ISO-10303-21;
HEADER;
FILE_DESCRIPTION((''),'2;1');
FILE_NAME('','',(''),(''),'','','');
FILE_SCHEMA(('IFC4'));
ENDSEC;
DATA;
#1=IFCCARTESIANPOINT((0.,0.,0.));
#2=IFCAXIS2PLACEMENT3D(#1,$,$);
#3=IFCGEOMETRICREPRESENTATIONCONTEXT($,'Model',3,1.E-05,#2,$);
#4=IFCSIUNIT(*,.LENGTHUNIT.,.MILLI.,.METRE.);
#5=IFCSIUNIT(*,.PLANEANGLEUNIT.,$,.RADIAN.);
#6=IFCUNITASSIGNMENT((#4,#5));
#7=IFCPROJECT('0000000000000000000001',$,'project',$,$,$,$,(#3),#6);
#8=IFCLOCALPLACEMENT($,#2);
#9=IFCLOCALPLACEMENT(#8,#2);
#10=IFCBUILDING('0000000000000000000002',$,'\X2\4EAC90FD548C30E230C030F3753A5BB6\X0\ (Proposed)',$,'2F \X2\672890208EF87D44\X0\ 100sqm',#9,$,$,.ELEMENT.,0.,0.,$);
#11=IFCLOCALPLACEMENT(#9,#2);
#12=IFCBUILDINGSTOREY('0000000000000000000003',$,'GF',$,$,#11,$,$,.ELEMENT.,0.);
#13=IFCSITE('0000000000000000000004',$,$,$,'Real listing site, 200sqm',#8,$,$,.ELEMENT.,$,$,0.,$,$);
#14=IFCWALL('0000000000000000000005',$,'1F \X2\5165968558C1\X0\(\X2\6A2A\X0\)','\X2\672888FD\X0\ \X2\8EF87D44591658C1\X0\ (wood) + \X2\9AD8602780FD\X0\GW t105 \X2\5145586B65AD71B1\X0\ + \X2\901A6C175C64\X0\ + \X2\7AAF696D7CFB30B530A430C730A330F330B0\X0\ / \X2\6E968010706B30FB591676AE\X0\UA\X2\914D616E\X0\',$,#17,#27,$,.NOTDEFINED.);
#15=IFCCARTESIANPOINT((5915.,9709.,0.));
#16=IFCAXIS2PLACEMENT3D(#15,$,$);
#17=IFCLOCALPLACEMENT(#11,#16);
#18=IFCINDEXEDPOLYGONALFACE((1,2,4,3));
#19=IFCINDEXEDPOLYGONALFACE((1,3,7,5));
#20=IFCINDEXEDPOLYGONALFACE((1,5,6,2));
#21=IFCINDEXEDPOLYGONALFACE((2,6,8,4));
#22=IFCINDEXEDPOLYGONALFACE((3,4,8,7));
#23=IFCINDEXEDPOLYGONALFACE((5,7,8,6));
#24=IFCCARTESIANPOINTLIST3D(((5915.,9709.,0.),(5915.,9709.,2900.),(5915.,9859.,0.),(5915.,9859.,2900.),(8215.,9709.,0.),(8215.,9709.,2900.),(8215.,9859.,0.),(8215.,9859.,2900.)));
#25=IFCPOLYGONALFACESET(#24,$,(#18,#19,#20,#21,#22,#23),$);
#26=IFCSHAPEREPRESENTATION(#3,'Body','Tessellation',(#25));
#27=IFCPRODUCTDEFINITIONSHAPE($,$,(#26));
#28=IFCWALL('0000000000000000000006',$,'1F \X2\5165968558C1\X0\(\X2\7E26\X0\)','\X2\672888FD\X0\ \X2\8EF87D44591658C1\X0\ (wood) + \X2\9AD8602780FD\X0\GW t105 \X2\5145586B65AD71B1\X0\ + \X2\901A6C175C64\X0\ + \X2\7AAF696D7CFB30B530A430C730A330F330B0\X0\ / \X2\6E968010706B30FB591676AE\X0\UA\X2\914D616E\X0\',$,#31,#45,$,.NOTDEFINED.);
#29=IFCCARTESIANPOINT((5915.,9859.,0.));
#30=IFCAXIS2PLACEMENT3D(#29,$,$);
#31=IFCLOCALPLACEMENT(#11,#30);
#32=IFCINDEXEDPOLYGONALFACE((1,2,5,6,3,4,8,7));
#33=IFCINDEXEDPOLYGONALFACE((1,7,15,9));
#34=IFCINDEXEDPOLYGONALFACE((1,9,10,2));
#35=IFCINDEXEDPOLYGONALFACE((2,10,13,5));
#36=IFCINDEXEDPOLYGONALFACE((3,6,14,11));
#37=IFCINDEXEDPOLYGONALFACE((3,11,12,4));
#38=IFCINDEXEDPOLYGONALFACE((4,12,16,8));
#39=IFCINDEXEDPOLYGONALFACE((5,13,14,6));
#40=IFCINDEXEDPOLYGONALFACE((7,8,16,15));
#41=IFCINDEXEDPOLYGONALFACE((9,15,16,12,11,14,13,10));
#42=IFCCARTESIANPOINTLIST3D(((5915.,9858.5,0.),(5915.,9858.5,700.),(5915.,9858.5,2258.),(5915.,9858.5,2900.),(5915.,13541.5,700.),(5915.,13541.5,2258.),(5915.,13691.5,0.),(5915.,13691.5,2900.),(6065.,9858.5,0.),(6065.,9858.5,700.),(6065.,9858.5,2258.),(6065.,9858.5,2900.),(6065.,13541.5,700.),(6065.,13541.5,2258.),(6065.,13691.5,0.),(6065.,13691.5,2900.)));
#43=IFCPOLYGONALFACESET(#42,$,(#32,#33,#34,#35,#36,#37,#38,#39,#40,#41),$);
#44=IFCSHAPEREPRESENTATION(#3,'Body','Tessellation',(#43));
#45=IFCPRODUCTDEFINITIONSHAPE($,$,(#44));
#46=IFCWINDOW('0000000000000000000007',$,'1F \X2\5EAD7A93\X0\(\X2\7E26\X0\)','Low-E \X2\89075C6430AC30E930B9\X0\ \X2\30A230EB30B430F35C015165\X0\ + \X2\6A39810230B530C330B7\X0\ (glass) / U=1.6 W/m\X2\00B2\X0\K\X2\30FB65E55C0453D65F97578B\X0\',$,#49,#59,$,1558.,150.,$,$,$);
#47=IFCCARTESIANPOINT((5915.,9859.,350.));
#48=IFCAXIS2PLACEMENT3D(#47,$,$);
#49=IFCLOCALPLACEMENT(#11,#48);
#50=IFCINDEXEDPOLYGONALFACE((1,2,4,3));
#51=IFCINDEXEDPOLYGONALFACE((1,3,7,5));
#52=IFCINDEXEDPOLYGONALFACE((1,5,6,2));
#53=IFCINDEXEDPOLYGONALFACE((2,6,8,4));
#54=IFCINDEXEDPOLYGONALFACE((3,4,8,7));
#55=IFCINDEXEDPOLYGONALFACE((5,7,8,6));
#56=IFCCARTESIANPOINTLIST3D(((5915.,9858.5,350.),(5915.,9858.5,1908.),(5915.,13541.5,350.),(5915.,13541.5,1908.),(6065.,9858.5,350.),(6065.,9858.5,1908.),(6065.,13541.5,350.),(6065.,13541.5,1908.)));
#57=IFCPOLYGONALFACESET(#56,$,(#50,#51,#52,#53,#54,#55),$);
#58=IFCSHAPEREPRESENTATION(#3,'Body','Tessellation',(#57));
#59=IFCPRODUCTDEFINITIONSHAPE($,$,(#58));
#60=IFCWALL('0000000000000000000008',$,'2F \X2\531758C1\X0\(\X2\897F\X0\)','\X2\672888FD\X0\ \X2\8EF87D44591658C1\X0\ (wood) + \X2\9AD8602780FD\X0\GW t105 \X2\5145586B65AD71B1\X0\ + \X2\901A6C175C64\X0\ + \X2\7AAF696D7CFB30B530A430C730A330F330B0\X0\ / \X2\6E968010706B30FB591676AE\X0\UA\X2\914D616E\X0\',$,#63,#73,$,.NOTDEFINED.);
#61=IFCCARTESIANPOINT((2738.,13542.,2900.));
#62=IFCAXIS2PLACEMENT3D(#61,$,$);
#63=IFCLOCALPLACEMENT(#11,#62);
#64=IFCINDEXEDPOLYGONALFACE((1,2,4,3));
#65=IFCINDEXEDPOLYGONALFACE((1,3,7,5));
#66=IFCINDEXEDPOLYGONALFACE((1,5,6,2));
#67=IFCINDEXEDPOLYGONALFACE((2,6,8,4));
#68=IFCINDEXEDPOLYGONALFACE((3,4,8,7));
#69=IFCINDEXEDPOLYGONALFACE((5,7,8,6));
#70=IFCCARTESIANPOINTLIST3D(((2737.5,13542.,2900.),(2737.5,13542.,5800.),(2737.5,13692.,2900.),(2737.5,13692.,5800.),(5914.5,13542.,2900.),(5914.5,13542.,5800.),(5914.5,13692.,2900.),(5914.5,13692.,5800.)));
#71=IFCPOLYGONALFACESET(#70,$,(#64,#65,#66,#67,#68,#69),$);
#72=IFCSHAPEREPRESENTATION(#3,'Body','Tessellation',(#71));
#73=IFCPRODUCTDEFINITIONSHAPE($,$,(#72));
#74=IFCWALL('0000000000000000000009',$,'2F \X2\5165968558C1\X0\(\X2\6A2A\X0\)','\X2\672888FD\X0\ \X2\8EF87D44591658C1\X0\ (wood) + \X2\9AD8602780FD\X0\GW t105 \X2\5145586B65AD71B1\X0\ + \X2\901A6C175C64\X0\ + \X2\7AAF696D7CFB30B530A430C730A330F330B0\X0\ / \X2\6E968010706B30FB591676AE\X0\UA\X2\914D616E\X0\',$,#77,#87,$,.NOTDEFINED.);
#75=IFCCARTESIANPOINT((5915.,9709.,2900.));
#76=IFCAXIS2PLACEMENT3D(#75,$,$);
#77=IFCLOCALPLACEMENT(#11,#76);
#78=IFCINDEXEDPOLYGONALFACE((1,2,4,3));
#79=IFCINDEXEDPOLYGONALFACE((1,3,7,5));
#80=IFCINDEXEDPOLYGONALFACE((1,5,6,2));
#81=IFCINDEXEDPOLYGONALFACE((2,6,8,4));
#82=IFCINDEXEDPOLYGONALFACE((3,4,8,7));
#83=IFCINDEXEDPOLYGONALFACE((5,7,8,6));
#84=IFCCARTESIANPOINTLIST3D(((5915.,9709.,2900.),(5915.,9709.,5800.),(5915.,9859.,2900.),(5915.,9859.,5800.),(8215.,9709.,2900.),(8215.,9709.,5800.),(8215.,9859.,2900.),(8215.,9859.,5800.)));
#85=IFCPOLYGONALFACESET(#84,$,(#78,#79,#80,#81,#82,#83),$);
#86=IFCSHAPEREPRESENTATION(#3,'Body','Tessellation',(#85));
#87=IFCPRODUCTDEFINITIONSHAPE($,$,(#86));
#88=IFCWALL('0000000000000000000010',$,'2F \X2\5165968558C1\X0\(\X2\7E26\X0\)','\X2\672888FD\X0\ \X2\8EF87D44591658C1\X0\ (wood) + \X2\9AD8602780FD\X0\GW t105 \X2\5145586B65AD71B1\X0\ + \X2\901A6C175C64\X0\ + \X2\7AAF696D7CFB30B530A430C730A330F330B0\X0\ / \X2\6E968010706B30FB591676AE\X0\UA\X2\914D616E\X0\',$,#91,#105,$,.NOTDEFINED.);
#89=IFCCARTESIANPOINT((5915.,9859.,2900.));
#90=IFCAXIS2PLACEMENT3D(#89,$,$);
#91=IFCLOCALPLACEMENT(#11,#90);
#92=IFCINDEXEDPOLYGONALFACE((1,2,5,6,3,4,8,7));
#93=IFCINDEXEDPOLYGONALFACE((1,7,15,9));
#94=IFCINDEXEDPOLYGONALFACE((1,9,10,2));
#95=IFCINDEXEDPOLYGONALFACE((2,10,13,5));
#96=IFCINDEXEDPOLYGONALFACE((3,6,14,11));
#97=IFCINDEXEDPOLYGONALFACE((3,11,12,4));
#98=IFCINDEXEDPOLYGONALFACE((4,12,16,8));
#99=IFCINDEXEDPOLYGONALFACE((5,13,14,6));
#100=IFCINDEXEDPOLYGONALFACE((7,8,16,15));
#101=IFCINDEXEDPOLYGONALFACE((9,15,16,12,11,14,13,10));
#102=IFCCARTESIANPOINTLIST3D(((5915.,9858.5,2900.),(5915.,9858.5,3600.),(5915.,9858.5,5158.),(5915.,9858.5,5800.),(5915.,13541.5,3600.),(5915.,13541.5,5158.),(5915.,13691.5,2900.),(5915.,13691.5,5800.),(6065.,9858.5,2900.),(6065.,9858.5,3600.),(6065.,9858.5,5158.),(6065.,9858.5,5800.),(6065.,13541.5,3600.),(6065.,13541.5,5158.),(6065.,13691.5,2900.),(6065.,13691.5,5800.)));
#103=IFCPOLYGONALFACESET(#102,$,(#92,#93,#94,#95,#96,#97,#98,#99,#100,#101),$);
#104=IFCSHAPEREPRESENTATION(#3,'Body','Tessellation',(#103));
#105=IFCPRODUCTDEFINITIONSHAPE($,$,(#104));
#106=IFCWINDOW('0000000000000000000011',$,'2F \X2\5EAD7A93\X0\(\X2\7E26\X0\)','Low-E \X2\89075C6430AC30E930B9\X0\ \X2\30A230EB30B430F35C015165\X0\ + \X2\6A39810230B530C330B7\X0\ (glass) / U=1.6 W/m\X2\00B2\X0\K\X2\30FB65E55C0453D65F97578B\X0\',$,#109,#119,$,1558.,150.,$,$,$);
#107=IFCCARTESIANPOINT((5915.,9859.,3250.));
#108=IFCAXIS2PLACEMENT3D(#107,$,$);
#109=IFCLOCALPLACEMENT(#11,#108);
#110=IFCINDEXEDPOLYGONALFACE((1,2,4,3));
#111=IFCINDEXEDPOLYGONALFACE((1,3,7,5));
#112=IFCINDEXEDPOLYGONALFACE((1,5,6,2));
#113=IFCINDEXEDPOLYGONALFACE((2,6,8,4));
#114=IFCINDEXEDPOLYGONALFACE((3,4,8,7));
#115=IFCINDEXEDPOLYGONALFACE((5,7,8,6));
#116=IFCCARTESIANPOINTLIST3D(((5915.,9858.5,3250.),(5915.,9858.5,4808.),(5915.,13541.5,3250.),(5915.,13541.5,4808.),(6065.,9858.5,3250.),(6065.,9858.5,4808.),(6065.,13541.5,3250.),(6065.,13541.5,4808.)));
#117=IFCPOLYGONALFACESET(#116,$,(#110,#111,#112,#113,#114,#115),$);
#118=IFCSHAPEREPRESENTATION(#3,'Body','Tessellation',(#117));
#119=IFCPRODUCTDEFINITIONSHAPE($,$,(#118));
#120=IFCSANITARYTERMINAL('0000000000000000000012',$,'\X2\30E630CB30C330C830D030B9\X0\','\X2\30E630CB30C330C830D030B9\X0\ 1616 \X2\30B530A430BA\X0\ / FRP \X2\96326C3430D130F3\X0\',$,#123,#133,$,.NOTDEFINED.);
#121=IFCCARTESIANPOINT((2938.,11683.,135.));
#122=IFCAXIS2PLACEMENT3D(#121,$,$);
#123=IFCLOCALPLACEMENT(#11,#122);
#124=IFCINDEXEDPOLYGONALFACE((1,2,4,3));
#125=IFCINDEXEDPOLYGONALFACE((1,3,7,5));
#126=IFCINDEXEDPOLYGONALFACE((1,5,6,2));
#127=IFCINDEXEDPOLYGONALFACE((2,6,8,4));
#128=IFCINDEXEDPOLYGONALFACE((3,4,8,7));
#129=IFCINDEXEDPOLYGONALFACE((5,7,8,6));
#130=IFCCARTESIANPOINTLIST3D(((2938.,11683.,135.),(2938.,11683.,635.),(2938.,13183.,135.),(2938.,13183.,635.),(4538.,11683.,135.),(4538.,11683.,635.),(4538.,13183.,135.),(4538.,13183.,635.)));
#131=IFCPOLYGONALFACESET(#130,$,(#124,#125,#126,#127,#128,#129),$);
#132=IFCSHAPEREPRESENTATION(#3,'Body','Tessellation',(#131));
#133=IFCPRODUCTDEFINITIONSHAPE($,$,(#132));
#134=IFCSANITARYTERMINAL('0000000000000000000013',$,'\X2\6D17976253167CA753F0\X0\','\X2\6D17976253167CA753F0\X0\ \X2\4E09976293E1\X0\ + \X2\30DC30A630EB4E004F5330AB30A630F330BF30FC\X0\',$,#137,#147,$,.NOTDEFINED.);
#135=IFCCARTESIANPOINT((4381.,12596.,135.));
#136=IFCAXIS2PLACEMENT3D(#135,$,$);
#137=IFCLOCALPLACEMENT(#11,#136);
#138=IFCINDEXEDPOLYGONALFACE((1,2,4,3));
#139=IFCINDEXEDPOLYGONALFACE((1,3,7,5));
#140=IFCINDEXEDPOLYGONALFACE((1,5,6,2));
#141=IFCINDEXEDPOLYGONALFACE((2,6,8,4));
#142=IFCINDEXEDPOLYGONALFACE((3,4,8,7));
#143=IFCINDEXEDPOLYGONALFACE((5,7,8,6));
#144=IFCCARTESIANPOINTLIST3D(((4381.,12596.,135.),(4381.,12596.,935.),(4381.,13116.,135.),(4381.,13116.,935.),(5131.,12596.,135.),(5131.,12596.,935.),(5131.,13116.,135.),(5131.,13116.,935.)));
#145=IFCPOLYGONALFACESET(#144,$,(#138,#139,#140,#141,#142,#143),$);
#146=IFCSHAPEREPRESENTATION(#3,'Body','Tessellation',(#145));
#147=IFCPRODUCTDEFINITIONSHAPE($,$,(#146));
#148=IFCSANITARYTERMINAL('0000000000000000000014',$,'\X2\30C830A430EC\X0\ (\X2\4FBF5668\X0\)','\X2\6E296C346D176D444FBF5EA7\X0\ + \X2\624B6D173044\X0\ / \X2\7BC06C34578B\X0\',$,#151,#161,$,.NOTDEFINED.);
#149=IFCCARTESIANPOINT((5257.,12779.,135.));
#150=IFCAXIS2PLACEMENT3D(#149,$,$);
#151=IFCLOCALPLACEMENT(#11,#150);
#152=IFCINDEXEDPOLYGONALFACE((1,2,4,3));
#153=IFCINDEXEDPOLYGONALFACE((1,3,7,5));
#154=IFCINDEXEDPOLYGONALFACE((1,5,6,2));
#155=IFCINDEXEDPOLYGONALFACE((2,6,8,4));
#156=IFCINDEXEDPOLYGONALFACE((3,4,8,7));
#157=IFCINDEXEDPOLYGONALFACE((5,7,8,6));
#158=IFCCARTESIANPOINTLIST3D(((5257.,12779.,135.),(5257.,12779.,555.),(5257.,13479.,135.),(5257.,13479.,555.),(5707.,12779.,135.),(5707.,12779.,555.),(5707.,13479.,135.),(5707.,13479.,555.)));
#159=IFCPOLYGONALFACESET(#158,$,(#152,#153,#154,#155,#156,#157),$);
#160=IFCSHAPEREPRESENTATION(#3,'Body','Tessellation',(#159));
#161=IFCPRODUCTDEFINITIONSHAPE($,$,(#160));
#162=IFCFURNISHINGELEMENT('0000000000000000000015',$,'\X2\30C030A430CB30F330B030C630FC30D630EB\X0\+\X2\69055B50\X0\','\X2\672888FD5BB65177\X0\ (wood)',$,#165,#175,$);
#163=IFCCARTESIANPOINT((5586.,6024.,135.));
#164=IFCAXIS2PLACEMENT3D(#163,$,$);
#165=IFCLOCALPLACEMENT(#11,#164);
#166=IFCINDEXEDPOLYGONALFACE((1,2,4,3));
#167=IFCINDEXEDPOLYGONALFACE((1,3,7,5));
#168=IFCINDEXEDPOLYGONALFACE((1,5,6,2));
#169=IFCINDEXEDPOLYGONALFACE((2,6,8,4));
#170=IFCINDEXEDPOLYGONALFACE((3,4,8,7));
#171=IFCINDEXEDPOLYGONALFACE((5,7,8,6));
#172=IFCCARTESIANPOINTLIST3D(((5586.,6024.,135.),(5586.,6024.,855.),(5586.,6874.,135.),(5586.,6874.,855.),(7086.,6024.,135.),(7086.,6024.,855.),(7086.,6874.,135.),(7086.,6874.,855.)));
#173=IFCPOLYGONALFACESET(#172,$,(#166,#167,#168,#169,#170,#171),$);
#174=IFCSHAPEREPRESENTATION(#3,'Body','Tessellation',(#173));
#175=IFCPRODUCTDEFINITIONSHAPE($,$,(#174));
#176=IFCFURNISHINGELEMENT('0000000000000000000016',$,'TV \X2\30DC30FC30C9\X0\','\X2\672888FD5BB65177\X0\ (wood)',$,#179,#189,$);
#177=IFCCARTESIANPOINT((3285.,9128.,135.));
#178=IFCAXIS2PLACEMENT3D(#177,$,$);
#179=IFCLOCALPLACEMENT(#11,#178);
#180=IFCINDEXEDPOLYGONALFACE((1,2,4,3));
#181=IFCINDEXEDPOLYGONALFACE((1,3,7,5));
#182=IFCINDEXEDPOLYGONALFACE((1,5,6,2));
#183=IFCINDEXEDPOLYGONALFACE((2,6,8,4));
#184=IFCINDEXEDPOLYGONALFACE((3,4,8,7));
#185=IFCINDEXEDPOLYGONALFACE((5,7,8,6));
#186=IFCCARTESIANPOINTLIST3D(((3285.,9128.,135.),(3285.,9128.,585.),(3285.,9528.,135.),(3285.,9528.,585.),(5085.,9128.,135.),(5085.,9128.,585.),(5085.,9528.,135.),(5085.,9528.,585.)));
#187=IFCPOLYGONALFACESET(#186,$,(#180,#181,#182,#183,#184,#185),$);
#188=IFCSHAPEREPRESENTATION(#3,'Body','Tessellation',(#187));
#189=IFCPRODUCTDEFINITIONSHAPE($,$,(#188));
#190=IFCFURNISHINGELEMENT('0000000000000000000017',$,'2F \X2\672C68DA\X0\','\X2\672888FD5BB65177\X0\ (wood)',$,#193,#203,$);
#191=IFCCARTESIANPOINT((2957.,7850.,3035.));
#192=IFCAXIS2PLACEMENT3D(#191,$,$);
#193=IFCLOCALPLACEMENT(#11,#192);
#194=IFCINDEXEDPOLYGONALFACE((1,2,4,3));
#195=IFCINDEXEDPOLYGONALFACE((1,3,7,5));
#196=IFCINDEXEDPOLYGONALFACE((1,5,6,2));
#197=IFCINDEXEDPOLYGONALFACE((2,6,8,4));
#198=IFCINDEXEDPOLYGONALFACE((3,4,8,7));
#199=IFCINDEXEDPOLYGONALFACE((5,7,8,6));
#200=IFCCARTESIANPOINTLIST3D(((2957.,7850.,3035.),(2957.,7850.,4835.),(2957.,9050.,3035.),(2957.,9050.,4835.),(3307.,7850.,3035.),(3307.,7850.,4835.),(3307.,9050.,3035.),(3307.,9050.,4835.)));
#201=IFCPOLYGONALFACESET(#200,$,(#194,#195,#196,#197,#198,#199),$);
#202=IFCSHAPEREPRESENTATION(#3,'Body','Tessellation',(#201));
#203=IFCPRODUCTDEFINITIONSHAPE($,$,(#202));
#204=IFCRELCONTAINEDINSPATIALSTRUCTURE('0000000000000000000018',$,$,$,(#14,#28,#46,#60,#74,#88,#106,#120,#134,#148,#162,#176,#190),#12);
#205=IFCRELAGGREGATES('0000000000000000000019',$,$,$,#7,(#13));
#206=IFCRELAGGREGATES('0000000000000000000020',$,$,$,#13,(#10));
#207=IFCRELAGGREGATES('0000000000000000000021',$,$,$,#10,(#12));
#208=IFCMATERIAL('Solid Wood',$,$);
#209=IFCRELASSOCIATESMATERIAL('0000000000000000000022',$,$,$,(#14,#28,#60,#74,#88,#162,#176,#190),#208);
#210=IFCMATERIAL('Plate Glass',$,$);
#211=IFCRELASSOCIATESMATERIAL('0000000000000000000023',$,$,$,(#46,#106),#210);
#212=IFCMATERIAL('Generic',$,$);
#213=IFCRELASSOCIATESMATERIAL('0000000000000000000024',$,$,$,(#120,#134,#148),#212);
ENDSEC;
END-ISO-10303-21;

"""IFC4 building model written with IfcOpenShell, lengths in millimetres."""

from ifc_helpers import new_model, si_unit, frame, frame_2d, origin, place, context, project, spatial, rectangle, extrude, material, element, fill, save


model = new_model("IFC4")

# Units and contexts
model_context = context("Model", 3, precision=1e-05, world=origin())
ifc_project = project(units=[si_unit("LENGTHUNIT", "METRE", prefix="MILLI"), si_unit("PLANEANGLEUNIT", "RADIAN")], contexts=[model_context])

# Site, building, storey
site_placement = place(None, origin())
site = spatial("IfcSite", under=ifc_project, at=site_placement, ObjectType="Real listing site, 200sqm", CompositionType="ELEMENT", RefElevation=0.0)
building_placement = place(site_placement, origin())
building = spatial("IfcBuilding", under=site, at=building_placement, Name="京都和モダン町家 (Proposed)", ObjectType="2F 木造軸組 100sqm", CompositionType="ELEMENT", ElevationOfRefHeight=0.0, ElevationOfTerrain=0.0)
storey_placement = place(building_placement, origin())
storey = spatial("IfcBuildingStorey", under=building, at=storey_placement, Name="GF", CompositionType="ELEMENT", Elevation=0.0)

# Shared definitions
ifc_material_1 = material(Name="Solid Wood")

# Wall
wall_1_placement = place(storey_placement, frame((5915.0, 9709.0, 0.0)))
element("IfcWall", 1, at=wall_1_placement, inside=storey, material=ifc_material_1, Name="1F 入隅壁(横)", Description="木製 軸組外壁 (wood) + 高性能GW t105 充填断熱 + 通気層 + 窯業系サイディング / 準耐火・外皮UA配慮", PredefinedType="NOTDEFINED", context=model_context, shape_type="SweptSolid", body=[
    extrude(rectangle(XDim=2300.0, YDim=150.0, at=frame_2d((1150.0, 75.0))), frame((5915.0, 9709.0, 0.0)), (0.0, 0.0, 1.0), 2900.0),
])

# Wall, opening, window
wall_2_placement = place(storey_placement, frame((5915.0, 9859.0, 0.0)))
wall_2 = element("IfcWall", 2, at=wall_2_placement, inside=storey, material=ifc_material_1, Name="1F 入隅壁(縦)", Description="木製 軸組外壁 (wood) + 高性能GW t105 充填断熱 + 通気層 + 窯業系サイディング / 準耐火・外皮UA配慮", PredefinedType="NOTDEFINED", context=model_context, shape_type="SweptSolid", body=[
    extrude(rectangle(XDim=150.0, YDim=3833.0, at=frame_2d((75.0, 1916.0))), frame((5915.0, 9859.0, 0.0)), (0.0, 0.0, 1.0), 2900.0),
])
opening_1_placement = place(storey_placement, frame((5915.0, 9859.0, 350.0)))
opening_1 = element("IfcOpeningElement", 3, at=opening_1_placement, cuts=wall_2, PredefinedType="NOTDEFINED", context=model_context, shape_type="SweptSolid", body=[
    extrude(rectangle(XDim=150.0, YDim=3683.0, at=frame_2d((75.0, 1841.0))), frame((5915.0, 9859.0, 350.0)), (0.0, 0.0, 1.0), 1558.0),
])
ifc_material_2 = material(Name="Plate Glass")
window_1_placement = place(storey_placement, frame((5915.0, 9859.0, 350.0)))
window_1 = element("IfcWindow", 4, at=window_1_placement, inside=storey, material=ifc_material_2, Name="1F 庭窓(縦)", Description="Low-E 複層ガラス アルゴン封入 + 樹脂サッシ (glass) / U=1.6 W/m²K・日射取得型", OverallHeight=1558.0, OverallWidth=150.0, context=model_context, shape_type="SweptSolid", body=[
    extrude(rectangle(XDim=150.0, YDim=3683.0, at=frame_2d((75.0, 1841.0))), frame((5915.0, 9859.0, 350.0)), (0.0, 0.0, 1.0), 1558.0),
])
fill(opening_1, window_1)

# Walls
wall_3_placement = place(storey_placement, frame((2738.0, 13542.0, 2900.0)))
element("IfcWall", 5, at=wall_3_placement, inside=storey, material=ifc_material_1, Name="2F 北壁(西)", Description="木製 軸組外壁 (wood) + 高性能GW t105 充填断熱 + 通気層 + 窯業系サイディング / 準耐火・外皮UA配慮", PredefinedType="NOTDEFINED", context=model_context, shape_type="SweptSolid", body=[
    extrude(rectangle(XDim=3177.0, YDim=150.0, at=frame_2d((1588.0, 75.0))), frame((2738.0, 13542.0, 2900.0)), (0.0, 0.0, 1.0), 2900.0),
])
wall_4_placement = place(storey_placement, frame((5915.0, 9709.0, 2900.0)))
element("IfcWall", 6, at=wall_4_placement, inside=storey, material=ifc_material_1, Name="2F 入隅壁(横)", Description="木製 軸組外壁 (wood) + 高性能GW t105 充填断熱 + 通気層 + 窯業系サイディング / 準耐火・外皮UA配慮", PredefinedType="NOTDEFINED", context=model_context, shape_type="SweptSolid", body=[
    extrude(rectangle(XDim=2300.0, YDim=150.0, at=frame_2d((1150.0, 75.0))), frame((5915.0, 9709.0, 2900.0)), (0.0, 0.0, 1.0), 2900.0),
])

# Wall, opening, window
wall_5_placement = place(storey_placement, frame((5915.0, 9859.0, 2900.0)))
wall_5 = element("IfcWall", 7, at=wall_5_placement, inside=storey, material=ifc_material_1, Name="2F 入隅壁(縦)", Description="木製 軸組外壁 (wood) + 高性能GW t105 充填断熱 + 通気層 + 窯業系サイディング / 準耐火・外皮UA配慮", PredefinedType="NOTDEFINED", context=model_context, shape_type="SweptSolid", body=[
    extrude(rectangle(XDim=150.0, YDim=3833.0, at=frame_2d((75.0, 1916.0))), frame((5915.0, 9859.0, 2900.0)), (0.0, 0.0, 1.0), 2900.0),
])
opening_2_placement = place(storey_placement, frame((5915.0, 9859.0, 3250.0)))
opening_2 = element("IfcOpeningElement", 8, at=opening_2_placement, cuts=wall_5, PredefinedType="NOTDEFINED", context=model_context, shape_type="SweptSolid", body=[
    extrude(rectangle(XDim=150.0, YDim=3683.0, at=frame_2d((75.0, 1841.0))), frame((5915.0, 9859.0, 3250.0)), (0.0, 0.0, 1.0), 1558.0),
])
window_2_placement = place(storey_placement, frame((5915.0, 9859.0, 3250.0)))
window_2 = element("IfcWindow", 9, at=window_2_placement, inside=storey, material=ifc_material_2, Name="2F 庭窓(縦)", Description="Low-E 複層ガラス アルゴン封入 + 樹脂サッシ (glass) / U=1.6 W/m²K・日射取得型", OverallHeight=1558.0, OverallWidth=150.0, context=model_context, shape_type="SweptSolid", body=[
    extrude(rectangle(XDim=150.0, YDim=3683.0, at=frame_2d((75.0, 1841.0))), frame((5915.0, 9859.0, 3250.0)), (0.0, 0.0, 1.0), 1558.0),
])
fill(opening_2, window_2)

# Shared definitions
ifc_material_3 = material(Name="Generic")

# Sanitary terminals
sanitary_terminal_1_placement = place(storey_placement, frame((2938.0, 11683.0, 135.0)))
element("IfcSanitaryTerminal", 10, at=sanitary_terminal_1_placement, inside=storey, material=ifc_material_3, Name="ユニットバス", Description="ユニットバス 1616 サイズ / FRP 防水パン", PredefinedType="NOTDEFINED", context=model_context, shape_type="SweptSolid", body=[
    extrude(rectangle(XDim=1600.0, YDim=1500.0, at=frame_2d((800.0, 750.0))), frame((2938.0, 11683.0, 135.0)), (0.0, 0.0, 1.0), 500.0),
])
sanitary_terminal_2_placement = place(storey_placement, frame((4381.0, 12596.0, 135.0)))
element("IfcSanitaryTerminal", 11, at=sanitary_terminal_2_placement, inside=storey, material=ifc_material_3, Name="洗面化粧台", Description="洗面化粧台 三面鏡 + ボウル一体カウンター", PredefinedType="NOTDEFINED", context=model_context, shape_type="SweptSolid", body=[
    extrude(rectangle(XDim=750.0, YDim=520.0, at=frame_2d((375.0, 260.0))), frame((4381.0, 12596.0, 135.0)), (0.0, 0.0, 1.0), 800.0),
])
sanitary_terminal_3_placement = place(storey_placement, frame((5257.0, 12779.0, 135.0)))
element("IfcSanitaryTerminal", 12, at=sanitary_terminal_3_placement, inside=storey, material=ifc_material_3, Name="トイレ (便器)", Description="温水洗浄便座 + 手洗い / 節水型", PredefinedType="NOTDEFINED", context=model_context, shape_type="SweptSolid", body=[
    extrude(rectangle(XDim=450.0, YDim=700.0, at=frame_2d((225.0, 350.0))), frame((5257.0, 12779.0, 135.0)), (0.0, 0.0, 1.0), 420.0),
])

# Furnishing elements
furnishing_1_placement = place(storey_placement, frame((5586.0, 6024.0, 135.0)))
element("IfcFurnishingElement", 13, at=furnishing_1_placement, inside=storey, material=ifc_material_1, Name="ダイニングテーブル+椅子", Description="木製家具 (wood)", context=model_context, shape_type="SweptSolid", body=[
    extrude(rectangle(XDim=1500.0, YDim=850.0, at=frame_2d((750.0, 425.0))), frame((5586.0, 6024.0, 135.0)), (0.0, 0.0, 1.0), 720.0),
])
furnishing_2_placement = place(storey_placement, frame((3285.0, 9128.0, 135.0)))
element("IfcFurnishingElement", 14, at=furnishing_2_placement, inside=storey, material=ifc_material_1, Name="TV ボード", Description="木製家具 (wood)", context=model_context, shape_type="SweptSolid", body=[
    extrude(rectangle(XDim=1800.0, YDim=400.0, at=frame_2d((900.0, 200.0))), frame((3285.0, 9128.0, 135.0)), (0.0, 0.0, 1.0), 450.0),
])
furnishing_3_placement = place(storey_placement, frame((2957.0, 7850.0, 3035.0)))
element("IfcFurnishingElement", 15, at=furnishing_3_placement, inside=storey, material=ifc_material_1, Name="2F 本棚", Description="木製家具 (wood)", context=model_context, shape_type="SweptSolid", body=[
    extrude(rectangle(XDim=350.0, YDim=1200.0, at=frame_2d((175.0, 600.0))), frame((2957.0, 7850.0, 3035.0)), (0.0, 0.0, 1.0), 1800.0),
])

save(model, "model.ifc")
